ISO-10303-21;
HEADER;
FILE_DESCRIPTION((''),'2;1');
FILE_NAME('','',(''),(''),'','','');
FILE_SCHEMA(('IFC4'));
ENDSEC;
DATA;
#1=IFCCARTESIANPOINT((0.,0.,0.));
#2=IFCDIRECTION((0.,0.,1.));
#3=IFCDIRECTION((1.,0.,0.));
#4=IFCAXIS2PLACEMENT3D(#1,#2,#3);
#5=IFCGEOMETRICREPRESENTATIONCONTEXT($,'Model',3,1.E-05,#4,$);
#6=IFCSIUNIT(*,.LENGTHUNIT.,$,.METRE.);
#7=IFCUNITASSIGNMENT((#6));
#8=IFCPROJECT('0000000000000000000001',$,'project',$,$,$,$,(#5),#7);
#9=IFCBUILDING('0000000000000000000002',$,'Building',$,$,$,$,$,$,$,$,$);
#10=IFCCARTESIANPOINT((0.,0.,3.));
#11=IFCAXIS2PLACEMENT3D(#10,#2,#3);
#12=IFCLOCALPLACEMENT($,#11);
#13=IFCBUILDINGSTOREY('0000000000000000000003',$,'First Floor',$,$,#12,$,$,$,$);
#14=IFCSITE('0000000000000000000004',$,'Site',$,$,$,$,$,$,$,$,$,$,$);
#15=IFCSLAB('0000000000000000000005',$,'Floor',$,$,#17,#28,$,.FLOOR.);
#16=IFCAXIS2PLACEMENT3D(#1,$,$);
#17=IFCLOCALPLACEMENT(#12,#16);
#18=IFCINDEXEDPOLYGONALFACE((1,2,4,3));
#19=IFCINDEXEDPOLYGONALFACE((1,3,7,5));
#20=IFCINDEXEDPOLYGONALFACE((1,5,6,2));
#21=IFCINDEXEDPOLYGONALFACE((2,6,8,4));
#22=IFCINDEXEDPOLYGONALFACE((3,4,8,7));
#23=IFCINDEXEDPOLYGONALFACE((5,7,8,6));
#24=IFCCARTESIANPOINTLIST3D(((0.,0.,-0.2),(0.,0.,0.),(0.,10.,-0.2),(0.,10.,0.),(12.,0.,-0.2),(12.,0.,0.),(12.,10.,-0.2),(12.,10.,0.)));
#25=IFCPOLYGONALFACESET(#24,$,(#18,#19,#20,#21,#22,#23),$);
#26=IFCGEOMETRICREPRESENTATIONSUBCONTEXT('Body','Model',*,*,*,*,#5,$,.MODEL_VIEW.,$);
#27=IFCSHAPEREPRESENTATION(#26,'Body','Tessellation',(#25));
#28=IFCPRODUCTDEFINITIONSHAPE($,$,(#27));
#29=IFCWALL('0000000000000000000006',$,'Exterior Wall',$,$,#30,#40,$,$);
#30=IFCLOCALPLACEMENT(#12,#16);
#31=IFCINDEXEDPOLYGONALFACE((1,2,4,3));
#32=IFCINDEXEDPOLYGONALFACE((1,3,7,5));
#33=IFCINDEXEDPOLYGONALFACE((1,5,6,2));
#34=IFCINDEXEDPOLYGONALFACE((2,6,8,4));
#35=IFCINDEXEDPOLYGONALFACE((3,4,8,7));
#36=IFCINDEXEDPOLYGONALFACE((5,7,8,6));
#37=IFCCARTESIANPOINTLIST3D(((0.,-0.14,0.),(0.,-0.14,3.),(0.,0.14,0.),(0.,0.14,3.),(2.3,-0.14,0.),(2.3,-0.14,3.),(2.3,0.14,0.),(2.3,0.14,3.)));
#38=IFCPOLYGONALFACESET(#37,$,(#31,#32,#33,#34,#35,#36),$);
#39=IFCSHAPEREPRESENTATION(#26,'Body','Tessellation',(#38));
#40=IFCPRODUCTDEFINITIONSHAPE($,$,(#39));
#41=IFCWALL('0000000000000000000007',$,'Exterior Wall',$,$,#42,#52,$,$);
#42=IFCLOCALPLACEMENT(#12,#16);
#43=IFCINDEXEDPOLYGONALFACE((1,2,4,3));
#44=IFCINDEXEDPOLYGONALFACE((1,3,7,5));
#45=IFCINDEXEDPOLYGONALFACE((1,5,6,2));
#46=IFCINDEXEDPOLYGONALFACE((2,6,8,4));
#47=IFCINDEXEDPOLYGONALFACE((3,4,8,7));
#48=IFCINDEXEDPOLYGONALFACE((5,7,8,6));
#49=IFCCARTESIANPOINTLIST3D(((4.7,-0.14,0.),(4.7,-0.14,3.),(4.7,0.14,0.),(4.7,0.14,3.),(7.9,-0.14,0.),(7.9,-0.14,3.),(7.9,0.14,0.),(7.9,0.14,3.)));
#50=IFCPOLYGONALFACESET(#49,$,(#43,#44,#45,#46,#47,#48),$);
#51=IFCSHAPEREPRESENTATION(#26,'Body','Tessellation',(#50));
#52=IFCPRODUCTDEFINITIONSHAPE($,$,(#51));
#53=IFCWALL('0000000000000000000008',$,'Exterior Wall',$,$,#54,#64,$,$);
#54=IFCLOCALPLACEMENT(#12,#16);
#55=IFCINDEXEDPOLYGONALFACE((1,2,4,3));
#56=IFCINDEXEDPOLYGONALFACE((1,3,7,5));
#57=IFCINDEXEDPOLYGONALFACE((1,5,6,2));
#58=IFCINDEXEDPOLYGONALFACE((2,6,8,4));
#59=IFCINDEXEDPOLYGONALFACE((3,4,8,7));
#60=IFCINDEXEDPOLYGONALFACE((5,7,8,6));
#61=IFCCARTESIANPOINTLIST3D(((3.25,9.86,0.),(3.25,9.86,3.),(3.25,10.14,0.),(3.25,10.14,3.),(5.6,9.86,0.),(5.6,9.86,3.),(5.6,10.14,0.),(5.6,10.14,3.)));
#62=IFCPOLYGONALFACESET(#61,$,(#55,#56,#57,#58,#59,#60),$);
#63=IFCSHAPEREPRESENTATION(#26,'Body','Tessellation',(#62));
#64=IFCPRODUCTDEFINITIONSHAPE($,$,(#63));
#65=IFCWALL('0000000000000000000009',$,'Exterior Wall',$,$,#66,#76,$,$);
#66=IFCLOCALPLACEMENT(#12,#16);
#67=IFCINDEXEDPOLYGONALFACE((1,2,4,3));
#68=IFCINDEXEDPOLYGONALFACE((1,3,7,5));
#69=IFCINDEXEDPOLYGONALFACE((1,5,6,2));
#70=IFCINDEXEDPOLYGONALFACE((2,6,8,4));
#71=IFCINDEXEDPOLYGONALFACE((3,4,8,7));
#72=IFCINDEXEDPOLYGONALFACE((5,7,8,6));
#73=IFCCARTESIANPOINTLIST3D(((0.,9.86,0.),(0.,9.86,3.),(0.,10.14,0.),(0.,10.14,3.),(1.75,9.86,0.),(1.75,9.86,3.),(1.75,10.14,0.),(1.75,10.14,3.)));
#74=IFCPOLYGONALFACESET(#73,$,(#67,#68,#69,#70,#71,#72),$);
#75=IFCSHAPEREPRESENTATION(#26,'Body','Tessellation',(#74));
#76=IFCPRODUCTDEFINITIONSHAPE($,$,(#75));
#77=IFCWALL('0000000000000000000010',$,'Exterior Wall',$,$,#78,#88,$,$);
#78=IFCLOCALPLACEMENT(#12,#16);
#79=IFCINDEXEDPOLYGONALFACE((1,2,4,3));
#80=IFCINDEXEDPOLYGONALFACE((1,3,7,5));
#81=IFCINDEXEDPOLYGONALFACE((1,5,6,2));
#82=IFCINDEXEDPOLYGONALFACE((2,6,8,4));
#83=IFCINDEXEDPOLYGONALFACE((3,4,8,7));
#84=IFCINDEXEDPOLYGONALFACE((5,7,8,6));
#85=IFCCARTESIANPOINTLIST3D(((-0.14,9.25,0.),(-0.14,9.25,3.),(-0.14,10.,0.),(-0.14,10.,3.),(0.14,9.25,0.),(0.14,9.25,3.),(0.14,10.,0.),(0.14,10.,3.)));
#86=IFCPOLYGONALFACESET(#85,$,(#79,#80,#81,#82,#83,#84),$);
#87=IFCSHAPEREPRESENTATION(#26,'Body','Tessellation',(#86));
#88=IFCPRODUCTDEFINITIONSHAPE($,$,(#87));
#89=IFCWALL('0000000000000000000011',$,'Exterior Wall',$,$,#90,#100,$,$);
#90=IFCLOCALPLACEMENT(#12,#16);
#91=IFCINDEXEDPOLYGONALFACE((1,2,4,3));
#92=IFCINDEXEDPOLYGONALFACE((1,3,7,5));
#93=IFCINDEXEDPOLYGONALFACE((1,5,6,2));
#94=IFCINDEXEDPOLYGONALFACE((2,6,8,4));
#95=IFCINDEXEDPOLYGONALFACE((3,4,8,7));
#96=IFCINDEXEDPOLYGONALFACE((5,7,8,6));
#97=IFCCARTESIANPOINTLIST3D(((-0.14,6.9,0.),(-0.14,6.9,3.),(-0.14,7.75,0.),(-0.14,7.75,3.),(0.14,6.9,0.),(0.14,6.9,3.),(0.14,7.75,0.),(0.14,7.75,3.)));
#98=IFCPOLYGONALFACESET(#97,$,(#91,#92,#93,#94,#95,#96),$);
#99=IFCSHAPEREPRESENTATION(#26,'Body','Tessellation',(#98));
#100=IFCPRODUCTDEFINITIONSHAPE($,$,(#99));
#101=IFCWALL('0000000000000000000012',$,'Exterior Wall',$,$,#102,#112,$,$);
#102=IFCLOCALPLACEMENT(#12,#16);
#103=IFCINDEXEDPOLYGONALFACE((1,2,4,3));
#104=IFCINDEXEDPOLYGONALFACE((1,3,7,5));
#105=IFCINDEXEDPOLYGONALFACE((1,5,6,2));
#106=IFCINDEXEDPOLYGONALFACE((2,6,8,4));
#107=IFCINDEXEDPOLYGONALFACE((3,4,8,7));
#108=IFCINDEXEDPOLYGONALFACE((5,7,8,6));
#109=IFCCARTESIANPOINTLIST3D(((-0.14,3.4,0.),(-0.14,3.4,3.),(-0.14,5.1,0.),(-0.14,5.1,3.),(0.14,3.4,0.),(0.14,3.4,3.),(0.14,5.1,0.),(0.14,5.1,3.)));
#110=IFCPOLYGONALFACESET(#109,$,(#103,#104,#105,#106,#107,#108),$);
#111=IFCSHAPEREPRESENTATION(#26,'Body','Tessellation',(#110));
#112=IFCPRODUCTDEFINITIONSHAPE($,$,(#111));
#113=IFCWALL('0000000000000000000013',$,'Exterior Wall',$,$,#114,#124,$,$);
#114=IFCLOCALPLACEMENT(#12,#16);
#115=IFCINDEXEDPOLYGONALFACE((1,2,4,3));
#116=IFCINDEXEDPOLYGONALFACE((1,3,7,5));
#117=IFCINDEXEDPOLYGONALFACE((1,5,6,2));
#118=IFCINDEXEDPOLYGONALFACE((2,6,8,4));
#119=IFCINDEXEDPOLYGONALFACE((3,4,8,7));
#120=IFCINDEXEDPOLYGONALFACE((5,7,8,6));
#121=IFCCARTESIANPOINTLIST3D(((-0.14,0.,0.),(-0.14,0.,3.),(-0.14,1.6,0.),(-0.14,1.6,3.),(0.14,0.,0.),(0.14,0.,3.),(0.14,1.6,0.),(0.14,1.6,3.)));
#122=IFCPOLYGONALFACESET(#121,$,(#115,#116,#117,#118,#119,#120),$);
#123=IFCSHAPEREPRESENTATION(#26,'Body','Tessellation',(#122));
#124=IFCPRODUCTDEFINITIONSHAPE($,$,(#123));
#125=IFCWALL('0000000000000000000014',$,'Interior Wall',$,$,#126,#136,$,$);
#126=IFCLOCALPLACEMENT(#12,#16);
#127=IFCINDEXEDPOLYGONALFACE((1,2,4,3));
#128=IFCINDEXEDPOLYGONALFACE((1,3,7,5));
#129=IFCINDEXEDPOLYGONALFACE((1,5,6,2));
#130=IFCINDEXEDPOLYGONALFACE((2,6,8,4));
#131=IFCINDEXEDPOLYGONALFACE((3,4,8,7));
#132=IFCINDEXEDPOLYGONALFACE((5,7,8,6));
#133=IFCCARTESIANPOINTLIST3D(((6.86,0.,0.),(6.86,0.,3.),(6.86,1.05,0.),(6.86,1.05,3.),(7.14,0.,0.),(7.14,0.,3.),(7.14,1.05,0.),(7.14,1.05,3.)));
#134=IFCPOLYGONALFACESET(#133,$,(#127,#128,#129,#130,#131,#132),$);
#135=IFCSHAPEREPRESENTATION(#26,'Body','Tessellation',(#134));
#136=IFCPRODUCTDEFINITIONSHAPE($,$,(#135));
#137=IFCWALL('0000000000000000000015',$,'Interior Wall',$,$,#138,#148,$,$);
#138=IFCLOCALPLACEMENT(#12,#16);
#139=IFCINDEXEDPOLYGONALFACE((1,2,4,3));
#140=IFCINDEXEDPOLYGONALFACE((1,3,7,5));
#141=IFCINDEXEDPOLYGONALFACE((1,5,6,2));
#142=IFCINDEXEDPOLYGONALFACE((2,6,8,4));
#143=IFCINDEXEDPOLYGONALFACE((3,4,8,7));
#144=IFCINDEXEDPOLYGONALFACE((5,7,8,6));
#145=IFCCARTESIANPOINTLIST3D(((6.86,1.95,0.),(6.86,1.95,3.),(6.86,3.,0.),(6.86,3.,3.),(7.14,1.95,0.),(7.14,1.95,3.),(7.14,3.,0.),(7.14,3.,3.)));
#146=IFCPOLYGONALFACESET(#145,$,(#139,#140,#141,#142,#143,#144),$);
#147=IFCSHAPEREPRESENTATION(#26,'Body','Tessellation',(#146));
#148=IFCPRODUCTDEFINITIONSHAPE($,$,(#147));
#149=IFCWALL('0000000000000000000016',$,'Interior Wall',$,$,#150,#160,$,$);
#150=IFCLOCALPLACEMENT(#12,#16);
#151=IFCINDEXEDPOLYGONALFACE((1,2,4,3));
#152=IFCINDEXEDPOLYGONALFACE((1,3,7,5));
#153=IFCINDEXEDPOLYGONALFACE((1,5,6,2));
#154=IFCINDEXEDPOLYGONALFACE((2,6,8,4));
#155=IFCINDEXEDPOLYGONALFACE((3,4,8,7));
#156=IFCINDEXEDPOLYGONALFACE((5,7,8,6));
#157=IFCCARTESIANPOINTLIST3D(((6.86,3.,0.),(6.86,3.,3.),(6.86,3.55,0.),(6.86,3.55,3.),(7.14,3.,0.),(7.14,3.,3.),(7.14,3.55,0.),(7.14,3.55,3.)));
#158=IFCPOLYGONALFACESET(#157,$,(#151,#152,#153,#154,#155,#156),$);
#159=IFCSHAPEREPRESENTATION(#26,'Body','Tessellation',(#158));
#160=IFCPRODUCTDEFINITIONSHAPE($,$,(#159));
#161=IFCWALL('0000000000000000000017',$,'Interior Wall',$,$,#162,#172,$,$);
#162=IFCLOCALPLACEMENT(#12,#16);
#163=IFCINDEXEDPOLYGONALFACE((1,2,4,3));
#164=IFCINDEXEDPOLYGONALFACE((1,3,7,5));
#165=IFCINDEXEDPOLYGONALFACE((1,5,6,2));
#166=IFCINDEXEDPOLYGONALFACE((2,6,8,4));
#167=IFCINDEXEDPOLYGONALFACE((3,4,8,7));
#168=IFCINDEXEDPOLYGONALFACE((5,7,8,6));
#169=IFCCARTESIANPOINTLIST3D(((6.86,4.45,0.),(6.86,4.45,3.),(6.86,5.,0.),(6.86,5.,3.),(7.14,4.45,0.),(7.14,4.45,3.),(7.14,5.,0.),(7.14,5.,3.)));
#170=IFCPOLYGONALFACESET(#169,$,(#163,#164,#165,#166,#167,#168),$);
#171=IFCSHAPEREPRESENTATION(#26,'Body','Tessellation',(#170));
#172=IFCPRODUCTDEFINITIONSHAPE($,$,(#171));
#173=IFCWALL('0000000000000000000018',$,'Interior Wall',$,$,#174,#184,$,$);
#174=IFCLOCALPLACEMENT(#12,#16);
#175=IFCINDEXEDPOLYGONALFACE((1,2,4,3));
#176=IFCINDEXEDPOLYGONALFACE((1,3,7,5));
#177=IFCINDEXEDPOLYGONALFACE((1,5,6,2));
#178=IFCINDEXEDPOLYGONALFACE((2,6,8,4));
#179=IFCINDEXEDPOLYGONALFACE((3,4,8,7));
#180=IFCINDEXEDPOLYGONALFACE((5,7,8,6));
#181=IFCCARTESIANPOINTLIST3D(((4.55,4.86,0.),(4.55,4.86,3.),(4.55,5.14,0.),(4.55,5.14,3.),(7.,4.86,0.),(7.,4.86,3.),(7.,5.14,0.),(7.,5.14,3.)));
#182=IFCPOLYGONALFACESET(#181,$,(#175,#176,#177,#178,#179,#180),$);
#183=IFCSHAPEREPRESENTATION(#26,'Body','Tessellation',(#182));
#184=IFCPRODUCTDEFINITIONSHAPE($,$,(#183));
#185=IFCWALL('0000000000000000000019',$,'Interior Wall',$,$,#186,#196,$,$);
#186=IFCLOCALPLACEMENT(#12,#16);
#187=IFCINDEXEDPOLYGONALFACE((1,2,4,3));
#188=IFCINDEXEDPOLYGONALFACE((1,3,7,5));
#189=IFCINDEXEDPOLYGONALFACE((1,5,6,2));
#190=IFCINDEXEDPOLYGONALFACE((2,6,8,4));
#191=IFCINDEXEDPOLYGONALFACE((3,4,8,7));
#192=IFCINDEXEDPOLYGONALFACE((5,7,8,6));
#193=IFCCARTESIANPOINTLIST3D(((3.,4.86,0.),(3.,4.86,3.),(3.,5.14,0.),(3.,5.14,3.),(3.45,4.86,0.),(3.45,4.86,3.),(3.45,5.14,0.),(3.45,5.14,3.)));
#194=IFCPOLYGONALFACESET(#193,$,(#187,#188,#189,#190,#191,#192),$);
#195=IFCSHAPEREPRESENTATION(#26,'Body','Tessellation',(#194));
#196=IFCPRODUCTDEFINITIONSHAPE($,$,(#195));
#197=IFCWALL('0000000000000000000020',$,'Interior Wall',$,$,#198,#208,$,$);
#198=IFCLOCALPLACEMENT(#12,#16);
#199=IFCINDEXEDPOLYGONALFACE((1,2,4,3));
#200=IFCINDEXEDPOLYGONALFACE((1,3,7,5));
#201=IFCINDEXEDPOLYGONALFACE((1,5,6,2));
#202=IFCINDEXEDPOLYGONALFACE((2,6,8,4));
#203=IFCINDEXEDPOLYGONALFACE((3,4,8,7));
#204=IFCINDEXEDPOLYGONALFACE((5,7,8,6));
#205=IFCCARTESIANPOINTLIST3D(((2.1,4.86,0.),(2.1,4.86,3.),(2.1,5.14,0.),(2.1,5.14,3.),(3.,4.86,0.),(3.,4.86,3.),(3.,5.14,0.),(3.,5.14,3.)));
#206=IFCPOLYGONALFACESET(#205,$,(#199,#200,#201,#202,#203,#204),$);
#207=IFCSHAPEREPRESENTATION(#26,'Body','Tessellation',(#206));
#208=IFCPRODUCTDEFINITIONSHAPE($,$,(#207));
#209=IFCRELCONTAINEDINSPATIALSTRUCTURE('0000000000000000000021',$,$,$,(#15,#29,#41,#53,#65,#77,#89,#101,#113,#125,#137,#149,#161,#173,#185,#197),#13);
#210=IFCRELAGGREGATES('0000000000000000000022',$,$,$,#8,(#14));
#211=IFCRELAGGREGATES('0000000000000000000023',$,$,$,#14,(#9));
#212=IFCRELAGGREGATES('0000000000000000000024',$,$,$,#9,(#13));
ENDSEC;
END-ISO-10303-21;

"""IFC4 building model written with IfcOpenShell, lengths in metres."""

from ifc_helpers import new_model, si_unit, frame, origin_with_axes, place, context, subcontext, project, spatial, indexed_curve, outline, extrude, element, save


model = new_model("IFC4")

# Units and contexts
model_context = context("Model", 3, precision=1e-05, world=origin_with_axes())
body_context = subcontext(model_context, "Body", "Model", "MODEL_VIEW")
ifc_project = project(units=[si_unit("LENGTHUNIT", "METRE")], contexts=[model_context])

# Site, building, storey
site = spatial("IfcSite", under=ifc_project, Name="Site")
building = spatial("IfcBuilding", under=site, Name="Building")
storey_placement = place(None, frame((0.0, 0.0, 3.0), z_axis=(0.0, 0.0, 1.0), x_axis=(1.0, 0.0, 0.0)))
storey = spatial("IfcBuildingStorey", under=building, at=storey_placement, Name="First Floor")

# Slab
slab_placement = place(storey_placement, frame((0.0, 0.0, -0.2), z_axis=(0.0, 0.0, 1.0), x_axis=(1.0, 0.0, 0.0)))
element("IfcSlab", 1, at=slab_placement, inside=storey, Name="Floor", PredefinedType="FLOOR", context=body_context, shape_type="SweptSolid", body=[
    extrude(outline(indexed_curve([(0.0, 0.0), (12.0, 0.0), (12.0, 10.0), (0.0, 10.0)])), None, (0.0, 0.0, 1.0), 0.2),
])

# Walls
wall_1_placement = place(storey_placement, origin_with_axes())
element("IfcWall", 2, at=wall_1_placement, inside=storey, Name="Exterior Wall", context=body_context, shape_type="SweptSolid", body=[
    extrude(outline(indexed_curve([(0.0, 0.0), (0.0, 0.28), (2.3, 0.28), (2.3, 0.0), (0.0, 0.0)], self_intersect=False)), frame((0.0, -0.14, 0.0), z_axis=(0.0, 0.0, 1.0), x_axis=(1.0, 0.0, 0.0)), (0.0, 0.0, 1.0), 3.0),
])
wall_2_placement = place(storey_placement, frame((4.7, 0.0, 0.0), z_axis=(0.0, 0.0, 1.0), x_axis=(1.0, 0.0, 0.0)))
element("IfcWall", 3, at=wall_2_placement, inside=storey, Name="Exterior Wall", context=body_context, shape_type="SweptSolid", body=[
    extrude(outline(indexed_curve([(0.0, 0.0), (0.0, 0.28), (3.2, 0.28), (3.2, 0.0), (0.0, 0.0)], self_intersect=False)), frame((0.0, -0.14, 0.0), z_axis=(0.0, 0.0, 1.0), x_axis=(1.0, 0.0, 0.0)), (0.0, 0.0, 1.0), 3.0),
])
wall_3_placement = place(storey_placement, frame((5.6, 10.0, 0.0), z_axis=(0.0, 0.0, 1.0), x_axis=(-1.0, 0.0, 0.0)))
element("IfcWall", 4, at=wall_3_placement, inside=storey, Name="Exterior Wall", context=body_context, shape_type="SweptSolid", body=[
    extrude(outline(indexed_curve([(0.0, 0.0), (0.0, 0.28), (2.35, 0.28), (2.35, 0.0), (0.0, 0.0)], self_intersect=False)), frame((0.0, -0.14, 0.0), z_axis=(0.0, 0.0, 1.0), x_axis=(1.0, 0.0, 0.0)), (0.0, 0.0, 1.0), 3.0),
])
wall_4_placement = place(storey_placement, frame((1.75, 10.0, 0.0), z_axis=(0.0, 0.0, 1.0), x_axis=(-1.0, 0.0, 0.0)))
element("IfcWall", 5, at=wall_4_placement, inside=storey, Name="Exterior Wall", context=body_context, shape_type="SweptSolid", body=[
    extrude(outline(indexed_curve([(0.0, 0.0), (0.0, 0.28), (1.75, 0.28), (1.75, 0.0), (0.0, 0.0)], self_intersect=False)), frame((0.0, -0.14, 0.0), z_axis=(0.0, 0.0, 1.0), x_axis=(1.0, 0.0, 0.0)), (0.0, 0.0, 1.0), 3.0),
])
wall_5_placement = place(storey_placement, frame((0.0, 10.0, 0.0), z_axis=(0.0, 0.0, 1.0), x_axis=(0.0, -1.0, 0.0)))
element("IfcWall", 6, at=wall_5_placement, inside=storey, Name="Exterior Wall", context=body_context, shape_type="SweptSolid", body=[
    extrude(outline(indexed_curve([(0.0, 0.0), (0.0, 0.28), (0.75, 0.28), (0.75, 0.0), (0.0, 0.0)], self_intersect=False)), frame((0.0, -0.14, 0.0), z_axis=(0.0, 0.0, 1.0), x_axis=(1.0, 0.0, 0.0)), (0.0, 0.0, 1.0), 3.0),
])
wall_6_placement = place(storey_placement, frame((0.0, 7.75, 0.0), z_axis=(0.0, 0.0, 1.0), x_axis=(0.0, -1.0, 0.0)))
element("IfcWall", 7, at=wall_6_placement, inside=storey, Name="Exterior Wall", context=body_context, shape_type="SweptSolid", body=[
    extrude(outline(indexed_curve([(0.0, 0.0), (0.0, 0.28), (0.85, 0.28), (0.85, 0.0), (0.0, 0.0)], self_intersect=False)), frame((0.0, -0.14, 0.0), z_axis=(0.0, 0.0, 1.0), x_axis=(1.0, 0.0, 0.0)), (0.0, 0.0, 1.0), 3.0),
])
wall_7_placement = place(storey_placement, frame((0.0, 5.1, 0.0), z_axis=(0.0, 0.0, 1.0), x_axis=(0.0, -1.0, 0.0)))
element("IfcWall", 8, at=wall_7_placement, inside=storey, Name="Exterior Wall", context=body_context, shape_type="SweptSolid", body=[
    extrude(outline(indexed_curve([(0.0, 0.0), (0.0, 0.28), (1.7, 0.28), (1.7, 0.0), (0.0, 0.0)], self_intersect=False)), frame((0.0, -0.14, 0.0), z_axis=(0.0, 0.0, 1.0), x_axis=(1.0, 0.0, 0.0)), (0.0, 0.0, 1.0), 3.0),
])
wall_8_placement = place(storey_placement, frame((0.0, 1.6, 0.0), z_axis=(0.0, 0.0, 1.0), x_axis=(0.0, -1.0, 0.0)))
element("IfcWall", 9, at=wall_8_placement, inside=storey, Name="Exterior Wall", context=body_context, shape_type="SweptSolid", body=[
    extrude(outline(indexed_curve([(0.0, 0.0), (0.0, 0.28), (1.6, 0.28), (1.6, 0.0), (0.0, 0.0)], self_intersect=False)), frame((0.0, -0.14, 0.0), z_axis=(0.0, 0.0, 1.0), x_axis=(1.0, 0.0, 0.0)), (0.0, 0.0, 1.0), 3.0),
])
for number, where, z_axis, x_axis, name in (
    (10, (7.0, 0.0, 0.0), (0.0, 0.0, 1.0), (0.0, 1.0, 0.0), "Interior Wall"),
    (11, (7.0, 1.95, 0.0), (0.0, 0.0, 1.0), (0.0, 1.0, 0.0), "Interior Wall"),
):
    element("IfcWall", number, at=place(storey_placement, frame(where, z_axis=z_axis, x_axis=x_axis)), inside=storey, Name=name, context=body_context, shape_type="SweptSolid", body=[
        extrude(outline(indexed_curve([(0.0, 0.0), (0.0, 0.28), (1.05, 0.28), (1.05, 0.0), (0.0, 0.0)], self_intersect=False)), frame((0.0, -0.14, 0.0), z_axis=(0.0, 0.0, 1.0), x_axis=(1.0, 0.0, 0.0)), (0.0, 0.0, 1.0), 3.0),
    ])
for number, where, z_axis, x_axis, name in (
    (12, (7.0, 3.0, 0.0), (0.0, 0.0, 1.0), (0.0, 1.0, 0.0), "Interior Wall"),
    (13, (7.0, 4.45, 0.0), (0.0, 0.0, 1.0), (0.0, 1.0, 0.0), "Interior Wall"),
):
    element("IfcWall", number, at=place(storey_placement, frame(where, z_axis=z_axis, x_axis=x_axis)), inside=storey, Name=name, context=body_context, shape_type="SweptSolid", body=[
        extrude(outline(indexed_curve([(0.0, 0.0), (0.0, 0.28), (0.55, 0.28), (0.55, 0.0), (0.0, 0.0)], self_intersect=False)), frame((0.0, -0.14, 0.0), z_axis=(0.0, 0.0, 1.0), x_axis=(1.0, 0.0, 0.0)), (0.0, 0.0, 1.0), 3.0),
    ])
wall_9_placement = place(storey_placement, frame((7.0, 5.0, 0.0), z_axis=(0.0, 0.0, 1.0), x_axis=(-1.0, 0.0, 0.0)))
element("IfcWall", 14, at=wall_9_placement, inside=storey, Name="Interior Wall", context=body_context, shape_type="SweptSolid", body=[
    extrude(outline(indexed_curve([(0.0, 0.0), (0.0, 0.28), (2.45, 0.28), (2.45, 0.0), (0.0, 0.0)], self_intersect=False)), frame((0.0, -0.14, 0.0), z_axis=(0.0, 0.0, 1.0), x_axis=(1.0, 0.0, 0.0)), (0.0, 0.0, 1.0), 3.0),
])
wall_10_placement = place(storey_placement, frame((3.45, 5.0, 0.0), z_axis=(0.0, 0.0, 1.0), x_axis=(-1.0, 0.0, 0.0)))
element("IfcWall", 15, at=wall_10_placement, inside=storey, Name="Interior Wall", context=body_context, shape_type="SweptSolid", body=[
    extrude(outline(indexed_curve([(0.0, 0.0), (0.0, 0.28), (0.45, 0.28), (0.45, 0.0), (0.0, 0.0)], self_intersect=False)), frame((0.0, -0.14, 0.0), z_axis=(0.0, 0.0, 1.0), x_axis=(1.0, 0.0, 0.0)), (0.0, 0.0, 1.0), 3.0),
])
for number, where, z_axis, x_axis, name in (
    (16, (3.0, 5.0, 0.0), (0.0, 0.0, 1.0), (-1.0, 0.0, 0.0), "Interior Wall"),
):
    element("IfcWall", number, at=place(storey_placement, frame(where, z_axis=z_axis, x_axis=x_axis)), inside=storey, Name=name, context=body_context, shape_type="SweptSolid", body=[
        extrude(outline(indexed_curve([(0.0, 0.0), (0.0, 0.28), (0.9, 0.28), (0.9, 0.0), (0.0, 0.0)], self_intersect=False)), frame((0.0, -0.14, 0.0), z_axis=(0.0, 0.0, 1.0), x_axis=(1.0, 0.0, 0.0)), (0.0, 0.0, 1.0), 3.0),
    ])

save(model, "model.ifc")
